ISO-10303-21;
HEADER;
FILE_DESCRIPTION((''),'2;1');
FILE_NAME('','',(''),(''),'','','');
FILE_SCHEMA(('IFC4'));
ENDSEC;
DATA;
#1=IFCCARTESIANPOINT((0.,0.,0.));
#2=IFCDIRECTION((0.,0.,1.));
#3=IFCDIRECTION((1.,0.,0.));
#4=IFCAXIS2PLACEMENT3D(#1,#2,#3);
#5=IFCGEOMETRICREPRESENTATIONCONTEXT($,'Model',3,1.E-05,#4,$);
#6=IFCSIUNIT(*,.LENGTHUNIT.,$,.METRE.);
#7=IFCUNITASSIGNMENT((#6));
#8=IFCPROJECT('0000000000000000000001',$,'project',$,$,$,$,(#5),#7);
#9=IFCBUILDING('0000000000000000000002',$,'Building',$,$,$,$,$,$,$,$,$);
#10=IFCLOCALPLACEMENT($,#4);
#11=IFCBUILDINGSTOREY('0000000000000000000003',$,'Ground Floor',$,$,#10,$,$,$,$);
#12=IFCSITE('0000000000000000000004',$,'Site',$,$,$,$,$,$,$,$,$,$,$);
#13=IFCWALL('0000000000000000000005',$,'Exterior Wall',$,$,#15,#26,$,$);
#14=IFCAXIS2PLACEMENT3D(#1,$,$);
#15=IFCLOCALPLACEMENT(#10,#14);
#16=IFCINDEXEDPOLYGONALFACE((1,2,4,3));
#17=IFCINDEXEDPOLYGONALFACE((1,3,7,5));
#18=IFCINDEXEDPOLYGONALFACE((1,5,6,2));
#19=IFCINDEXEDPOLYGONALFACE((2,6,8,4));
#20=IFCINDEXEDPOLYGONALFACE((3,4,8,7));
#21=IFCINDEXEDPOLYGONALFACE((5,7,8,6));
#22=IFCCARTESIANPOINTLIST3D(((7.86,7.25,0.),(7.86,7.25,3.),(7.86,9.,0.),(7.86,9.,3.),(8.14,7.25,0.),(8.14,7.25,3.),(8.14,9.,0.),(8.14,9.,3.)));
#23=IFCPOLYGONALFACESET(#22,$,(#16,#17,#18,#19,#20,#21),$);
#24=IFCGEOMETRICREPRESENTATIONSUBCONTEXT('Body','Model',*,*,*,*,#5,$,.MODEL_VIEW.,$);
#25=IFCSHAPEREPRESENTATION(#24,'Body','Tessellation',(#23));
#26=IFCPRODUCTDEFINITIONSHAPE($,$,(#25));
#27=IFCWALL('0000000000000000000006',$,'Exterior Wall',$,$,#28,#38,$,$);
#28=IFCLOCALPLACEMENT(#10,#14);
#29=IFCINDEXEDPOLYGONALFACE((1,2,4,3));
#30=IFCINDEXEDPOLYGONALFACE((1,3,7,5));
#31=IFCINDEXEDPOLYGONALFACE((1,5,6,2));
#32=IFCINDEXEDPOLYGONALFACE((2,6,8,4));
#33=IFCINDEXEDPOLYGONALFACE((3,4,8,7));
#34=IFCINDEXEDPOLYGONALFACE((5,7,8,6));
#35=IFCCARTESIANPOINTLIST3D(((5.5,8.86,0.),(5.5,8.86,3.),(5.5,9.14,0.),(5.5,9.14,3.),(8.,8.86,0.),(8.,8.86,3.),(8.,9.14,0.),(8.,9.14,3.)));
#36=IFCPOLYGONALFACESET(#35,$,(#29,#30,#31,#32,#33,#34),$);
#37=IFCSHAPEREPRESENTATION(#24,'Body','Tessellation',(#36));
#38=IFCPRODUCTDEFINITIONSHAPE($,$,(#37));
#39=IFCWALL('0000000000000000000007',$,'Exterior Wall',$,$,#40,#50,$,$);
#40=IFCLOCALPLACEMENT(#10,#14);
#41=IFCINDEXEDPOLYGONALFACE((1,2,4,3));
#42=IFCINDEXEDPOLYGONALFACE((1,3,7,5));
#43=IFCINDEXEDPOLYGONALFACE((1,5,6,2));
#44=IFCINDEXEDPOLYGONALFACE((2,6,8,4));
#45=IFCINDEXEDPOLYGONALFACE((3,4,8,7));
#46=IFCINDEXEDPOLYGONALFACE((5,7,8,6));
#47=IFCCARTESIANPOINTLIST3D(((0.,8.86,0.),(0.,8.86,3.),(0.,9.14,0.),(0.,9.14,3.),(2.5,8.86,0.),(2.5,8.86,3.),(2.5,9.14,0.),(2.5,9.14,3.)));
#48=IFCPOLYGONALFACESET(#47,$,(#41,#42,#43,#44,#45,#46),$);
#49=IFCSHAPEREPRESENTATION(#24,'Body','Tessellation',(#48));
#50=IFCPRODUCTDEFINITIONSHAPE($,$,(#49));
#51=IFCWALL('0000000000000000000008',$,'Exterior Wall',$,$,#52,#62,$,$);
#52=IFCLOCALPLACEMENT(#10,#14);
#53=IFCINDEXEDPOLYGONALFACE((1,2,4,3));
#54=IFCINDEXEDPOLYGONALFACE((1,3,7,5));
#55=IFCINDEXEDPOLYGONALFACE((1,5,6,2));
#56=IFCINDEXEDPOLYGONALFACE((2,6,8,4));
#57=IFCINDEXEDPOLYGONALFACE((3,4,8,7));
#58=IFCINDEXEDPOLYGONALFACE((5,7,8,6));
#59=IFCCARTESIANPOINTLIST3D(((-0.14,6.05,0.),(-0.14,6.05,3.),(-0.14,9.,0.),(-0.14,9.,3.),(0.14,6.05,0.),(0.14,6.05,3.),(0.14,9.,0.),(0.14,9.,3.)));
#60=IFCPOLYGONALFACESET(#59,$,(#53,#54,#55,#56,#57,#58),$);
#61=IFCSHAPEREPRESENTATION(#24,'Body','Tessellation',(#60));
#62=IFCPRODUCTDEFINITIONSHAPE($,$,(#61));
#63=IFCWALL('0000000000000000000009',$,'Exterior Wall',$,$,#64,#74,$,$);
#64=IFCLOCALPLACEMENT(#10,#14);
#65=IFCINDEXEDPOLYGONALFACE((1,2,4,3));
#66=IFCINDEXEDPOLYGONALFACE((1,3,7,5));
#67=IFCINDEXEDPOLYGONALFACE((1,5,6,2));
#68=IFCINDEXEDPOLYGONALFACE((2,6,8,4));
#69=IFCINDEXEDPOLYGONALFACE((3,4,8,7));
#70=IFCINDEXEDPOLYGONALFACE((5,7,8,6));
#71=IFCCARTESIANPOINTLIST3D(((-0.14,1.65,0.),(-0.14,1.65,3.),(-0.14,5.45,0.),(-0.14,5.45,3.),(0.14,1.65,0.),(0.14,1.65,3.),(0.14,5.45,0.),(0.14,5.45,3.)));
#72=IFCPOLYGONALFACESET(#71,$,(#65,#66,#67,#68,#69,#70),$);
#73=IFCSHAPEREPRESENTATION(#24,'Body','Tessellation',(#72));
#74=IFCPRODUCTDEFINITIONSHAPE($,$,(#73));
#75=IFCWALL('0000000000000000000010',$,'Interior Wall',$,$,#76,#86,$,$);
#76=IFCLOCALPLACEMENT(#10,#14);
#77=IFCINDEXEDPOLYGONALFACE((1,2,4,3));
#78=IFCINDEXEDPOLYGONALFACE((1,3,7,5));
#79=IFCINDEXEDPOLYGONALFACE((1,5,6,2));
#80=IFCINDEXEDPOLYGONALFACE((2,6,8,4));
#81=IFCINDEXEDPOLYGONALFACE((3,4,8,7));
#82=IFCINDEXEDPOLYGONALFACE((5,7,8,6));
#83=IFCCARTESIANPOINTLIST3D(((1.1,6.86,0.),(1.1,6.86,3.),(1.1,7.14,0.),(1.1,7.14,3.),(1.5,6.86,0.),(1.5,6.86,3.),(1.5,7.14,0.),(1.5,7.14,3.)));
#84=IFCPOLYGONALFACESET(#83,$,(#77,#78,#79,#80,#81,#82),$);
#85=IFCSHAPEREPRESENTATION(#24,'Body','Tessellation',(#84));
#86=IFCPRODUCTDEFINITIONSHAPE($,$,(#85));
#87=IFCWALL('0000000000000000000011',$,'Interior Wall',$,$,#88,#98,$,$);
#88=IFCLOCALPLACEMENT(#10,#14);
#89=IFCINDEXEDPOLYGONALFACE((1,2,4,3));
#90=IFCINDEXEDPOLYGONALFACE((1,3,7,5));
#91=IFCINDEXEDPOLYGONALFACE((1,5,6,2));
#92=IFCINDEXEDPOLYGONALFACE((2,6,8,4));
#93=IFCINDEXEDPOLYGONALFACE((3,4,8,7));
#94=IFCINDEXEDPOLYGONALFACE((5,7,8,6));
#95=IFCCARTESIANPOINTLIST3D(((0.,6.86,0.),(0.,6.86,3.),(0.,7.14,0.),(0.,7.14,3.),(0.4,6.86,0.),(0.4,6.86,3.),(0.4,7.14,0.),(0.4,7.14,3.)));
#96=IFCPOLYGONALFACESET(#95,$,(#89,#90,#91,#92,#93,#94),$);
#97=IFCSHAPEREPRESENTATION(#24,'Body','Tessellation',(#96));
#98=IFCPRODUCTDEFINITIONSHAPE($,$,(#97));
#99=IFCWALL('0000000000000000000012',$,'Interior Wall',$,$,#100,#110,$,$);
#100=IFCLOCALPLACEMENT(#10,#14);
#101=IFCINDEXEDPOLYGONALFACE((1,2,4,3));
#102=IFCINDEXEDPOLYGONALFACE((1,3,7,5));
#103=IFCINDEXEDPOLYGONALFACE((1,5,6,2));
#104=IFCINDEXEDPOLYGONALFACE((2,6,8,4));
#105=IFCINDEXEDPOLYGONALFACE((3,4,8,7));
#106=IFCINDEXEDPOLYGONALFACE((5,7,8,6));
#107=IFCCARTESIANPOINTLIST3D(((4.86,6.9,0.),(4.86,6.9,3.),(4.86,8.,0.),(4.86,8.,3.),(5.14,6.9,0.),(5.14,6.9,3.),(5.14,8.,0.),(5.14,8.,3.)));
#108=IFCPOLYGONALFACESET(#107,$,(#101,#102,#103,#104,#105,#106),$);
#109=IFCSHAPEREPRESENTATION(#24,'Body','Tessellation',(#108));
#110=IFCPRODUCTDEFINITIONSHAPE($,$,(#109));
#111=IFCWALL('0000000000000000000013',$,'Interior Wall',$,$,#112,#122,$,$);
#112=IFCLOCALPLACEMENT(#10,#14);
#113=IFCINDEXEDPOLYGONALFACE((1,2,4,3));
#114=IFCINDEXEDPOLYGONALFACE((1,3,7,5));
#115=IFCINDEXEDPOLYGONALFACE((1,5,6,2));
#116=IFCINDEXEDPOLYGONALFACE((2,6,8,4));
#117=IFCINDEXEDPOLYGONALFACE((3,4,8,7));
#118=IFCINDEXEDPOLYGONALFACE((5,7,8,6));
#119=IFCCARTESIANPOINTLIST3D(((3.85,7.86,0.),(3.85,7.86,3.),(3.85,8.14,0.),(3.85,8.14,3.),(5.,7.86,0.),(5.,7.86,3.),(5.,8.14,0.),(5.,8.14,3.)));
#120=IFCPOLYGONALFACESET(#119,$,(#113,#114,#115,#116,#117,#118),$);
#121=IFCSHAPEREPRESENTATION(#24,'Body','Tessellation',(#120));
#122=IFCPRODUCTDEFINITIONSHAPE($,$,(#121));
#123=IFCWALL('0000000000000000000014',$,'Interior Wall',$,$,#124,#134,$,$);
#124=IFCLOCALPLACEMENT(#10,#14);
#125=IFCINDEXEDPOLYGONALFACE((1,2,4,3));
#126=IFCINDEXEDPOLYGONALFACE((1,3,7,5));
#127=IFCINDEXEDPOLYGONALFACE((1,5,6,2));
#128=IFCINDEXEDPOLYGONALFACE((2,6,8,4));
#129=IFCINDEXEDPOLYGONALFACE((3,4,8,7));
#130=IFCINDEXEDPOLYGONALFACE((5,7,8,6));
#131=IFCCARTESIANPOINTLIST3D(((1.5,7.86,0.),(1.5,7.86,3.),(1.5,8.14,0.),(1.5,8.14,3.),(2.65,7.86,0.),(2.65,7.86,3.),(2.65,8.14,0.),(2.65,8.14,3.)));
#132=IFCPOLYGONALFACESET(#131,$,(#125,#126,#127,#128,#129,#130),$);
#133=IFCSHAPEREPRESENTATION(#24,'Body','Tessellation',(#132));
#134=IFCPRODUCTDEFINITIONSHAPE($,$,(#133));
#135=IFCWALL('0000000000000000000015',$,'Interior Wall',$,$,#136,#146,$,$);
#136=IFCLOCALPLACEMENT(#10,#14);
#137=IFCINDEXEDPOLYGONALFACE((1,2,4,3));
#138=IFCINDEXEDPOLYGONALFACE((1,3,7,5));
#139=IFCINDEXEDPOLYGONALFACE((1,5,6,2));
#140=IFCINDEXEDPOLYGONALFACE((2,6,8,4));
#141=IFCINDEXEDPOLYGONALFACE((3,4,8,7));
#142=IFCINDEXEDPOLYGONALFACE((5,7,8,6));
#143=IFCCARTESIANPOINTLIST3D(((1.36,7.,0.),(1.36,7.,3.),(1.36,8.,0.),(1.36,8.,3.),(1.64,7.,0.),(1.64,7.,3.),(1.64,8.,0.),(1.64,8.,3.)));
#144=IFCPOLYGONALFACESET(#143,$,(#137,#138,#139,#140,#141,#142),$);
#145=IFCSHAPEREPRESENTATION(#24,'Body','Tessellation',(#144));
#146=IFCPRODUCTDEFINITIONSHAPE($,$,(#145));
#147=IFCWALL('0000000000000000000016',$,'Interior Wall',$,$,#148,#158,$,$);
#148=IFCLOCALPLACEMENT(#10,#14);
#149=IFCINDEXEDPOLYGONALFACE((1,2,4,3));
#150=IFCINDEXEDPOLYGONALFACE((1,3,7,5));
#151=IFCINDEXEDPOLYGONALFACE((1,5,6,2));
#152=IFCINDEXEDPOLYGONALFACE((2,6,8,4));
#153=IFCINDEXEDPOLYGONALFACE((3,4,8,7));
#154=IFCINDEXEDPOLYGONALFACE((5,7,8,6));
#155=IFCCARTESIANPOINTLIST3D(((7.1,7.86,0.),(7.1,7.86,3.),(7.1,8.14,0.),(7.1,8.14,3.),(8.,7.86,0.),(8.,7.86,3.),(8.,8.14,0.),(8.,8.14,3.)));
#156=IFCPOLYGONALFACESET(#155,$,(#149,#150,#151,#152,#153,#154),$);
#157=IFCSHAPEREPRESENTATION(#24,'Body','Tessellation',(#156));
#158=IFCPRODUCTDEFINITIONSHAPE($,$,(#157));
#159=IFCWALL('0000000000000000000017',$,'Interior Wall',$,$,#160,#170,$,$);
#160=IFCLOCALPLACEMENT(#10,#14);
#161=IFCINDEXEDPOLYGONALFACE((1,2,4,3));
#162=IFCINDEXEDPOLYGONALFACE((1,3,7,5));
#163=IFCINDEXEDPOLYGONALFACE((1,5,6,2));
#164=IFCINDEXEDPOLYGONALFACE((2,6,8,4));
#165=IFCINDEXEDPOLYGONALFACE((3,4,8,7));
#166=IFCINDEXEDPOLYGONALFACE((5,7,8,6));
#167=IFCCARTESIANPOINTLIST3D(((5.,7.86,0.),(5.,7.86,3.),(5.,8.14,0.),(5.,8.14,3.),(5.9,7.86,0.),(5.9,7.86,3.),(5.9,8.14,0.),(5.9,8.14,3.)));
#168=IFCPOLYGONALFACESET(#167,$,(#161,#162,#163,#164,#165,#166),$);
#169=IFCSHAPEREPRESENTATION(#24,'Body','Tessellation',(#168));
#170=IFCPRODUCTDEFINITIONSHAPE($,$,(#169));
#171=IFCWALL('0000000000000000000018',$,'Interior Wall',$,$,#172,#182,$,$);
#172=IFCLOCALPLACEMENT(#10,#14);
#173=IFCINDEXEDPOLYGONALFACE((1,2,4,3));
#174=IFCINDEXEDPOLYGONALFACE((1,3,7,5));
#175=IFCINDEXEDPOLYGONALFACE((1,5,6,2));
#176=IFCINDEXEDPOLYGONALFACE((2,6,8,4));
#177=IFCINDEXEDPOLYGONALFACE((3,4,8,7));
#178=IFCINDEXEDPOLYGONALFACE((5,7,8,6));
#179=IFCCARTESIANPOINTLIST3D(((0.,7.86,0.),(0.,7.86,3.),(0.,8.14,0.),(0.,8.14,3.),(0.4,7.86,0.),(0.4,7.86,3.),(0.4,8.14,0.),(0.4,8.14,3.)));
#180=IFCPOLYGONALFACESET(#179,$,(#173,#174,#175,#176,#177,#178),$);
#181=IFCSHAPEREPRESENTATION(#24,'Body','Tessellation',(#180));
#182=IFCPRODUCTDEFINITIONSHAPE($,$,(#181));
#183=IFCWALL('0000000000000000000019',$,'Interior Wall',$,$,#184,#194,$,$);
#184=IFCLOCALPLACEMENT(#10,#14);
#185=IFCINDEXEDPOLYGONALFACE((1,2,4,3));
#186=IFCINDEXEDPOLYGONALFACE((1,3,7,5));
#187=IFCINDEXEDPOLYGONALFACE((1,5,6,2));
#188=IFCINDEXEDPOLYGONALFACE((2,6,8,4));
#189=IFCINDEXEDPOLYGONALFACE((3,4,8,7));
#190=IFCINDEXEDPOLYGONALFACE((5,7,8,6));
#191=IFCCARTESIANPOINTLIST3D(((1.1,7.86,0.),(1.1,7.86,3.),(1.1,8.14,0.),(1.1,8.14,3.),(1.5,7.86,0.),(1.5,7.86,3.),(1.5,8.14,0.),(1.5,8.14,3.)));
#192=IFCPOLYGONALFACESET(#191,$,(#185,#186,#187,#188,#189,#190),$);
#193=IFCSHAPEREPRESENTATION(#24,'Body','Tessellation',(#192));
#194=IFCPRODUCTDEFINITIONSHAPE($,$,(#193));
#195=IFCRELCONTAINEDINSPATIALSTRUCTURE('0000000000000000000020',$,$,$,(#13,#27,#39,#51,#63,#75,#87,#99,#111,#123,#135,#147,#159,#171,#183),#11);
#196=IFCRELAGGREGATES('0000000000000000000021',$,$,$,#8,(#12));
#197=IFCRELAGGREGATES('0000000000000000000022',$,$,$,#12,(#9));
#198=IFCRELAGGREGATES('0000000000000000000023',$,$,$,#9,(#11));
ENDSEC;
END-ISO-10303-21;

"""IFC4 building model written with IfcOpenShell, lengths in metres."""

from ifc_helpers import new_model, si_unit, frame, origin_with_axes, place, context, subcontext, project, spatial, indexed_curve, outline, extrude, element, save


model = new_model("IFC4")

# Units and contexts
model_context = context("Model", 3, precision=1e-05, world=origin_with_axes())
body_context = subcontext(model_context, "Body", "Model", "MODEL_VIEW")
ifc_project = project(units=[si_unit("LENGTHUNIT", "METRE")], contexts=[model_context])

# Site, building, storey
site = spatial("IfcSite", under=ifc_project, Name="Site")
building = spatial("IfcBuilding", under=site, Name="Building")
storey_placement = place(None, origin_with_axes())
storey = spatial("IfcBuildingStorey", under=building, at=storey_placement, Name="Ground Floor")

# Walls
wall_1_placement = place(storey_placement, frame((8.0, 7.25, 0.0), z_axis=(0.0, 0.0, 1.0), x_axis=(0.0, 1.0, 0.0)))
element("IfcWall", 1, at=wall_1_placement, inside=storey, Name="Exterior Wall", context=body_context, shape_type="SweptSolid", body=[
    extrude(outline(indexed_curve([(0.0, 0.0), (0.0, 0.28), (1.75, 0.28), (1.75, 0.0), (0.0, 0.0)], self_intersect=False)), frame((0.0, -0.14, 0.0), z_axis=(0.0, 0.0, 1.0), x_axis=(1.0, 0.0, 0.0)), (0.0, 0.0, 1.0), 3.0),
])
for number, where, z_axis, x_axis, name in (
    (2, (8.0, 9.0, 0.0), (0.0, 0.0, 1.0), (-1.0, 0.0, 0.0), "Exterior Wall"),
    (3, (2.5, 9.0, 0.0), (0.0, 0.0, 1.0), (-1.0, 0.0, 0.0), "Exterior Wall"),
):
    element("IfcWall", number, at=place(storey_placement, frame(where, z_axis=z_axis, x_axis=x_axis)), inside=storey, Name=name, context=body_context, shape_type="SweptSolid", body=[
        extrude(outline(indexed_curve([(0.0, 0.0), (0.0, 0.28), (2.5, 0.28), (2.5, 0.0), (0.0, 0.0)], self_intersect=False)), frame((0.0, -0.14, 0.0), z_axis=(0.0, 0.0, 1.0), x_axis=(1.0, 0.0, 0.0)), (0.0, 0.0, 1.0), 3.0),
    ])
wall_2_placement = place(storey_placement, frame((0.0, 9.0, 0.0), z_axis=(0.0, 0.0, 1.0), x_axis=(0.0, -1.0, 0.0)))
element("IfcWall", 4, at=wall_2_placement, inside=storey, Name="Exterior Wall", context=body_context, shape_type="SweptSolid", body=[
    extrude(outline(indexed_curve([(0.0, 0.0), (0.0, 0.28), (2.95, 0.28), (2.95, 0.0), (0.0, 0.0)], self_intersect=False)), frame((0.0, -0.14, 0.0), z_axis=(0.0, 0.0, 1.0), x_axis=(1.0, 0.0, 0.0)), (0.0, 0.0, 1.0), 3.0),
])
wall_3_placement = place(storey_placement, frame((0.0, 5.45, 0.0), z_axis=(0.0, 0.0, 1.0), x_axis=(0.0, -1.0, 0.0)))
element("IfcWall", 5, at=wall_3_placement, inside=storey, Name="Exterior Wall", context=body_context, shape_type="SweptSolid", body=[
    extrude(outline(indexed_curve([(0.0, 0.0), (0.0, 0.28), (3.8, 0.28), (3.8, 0.0), (0.0, 0.0)], self_intersect=False)), frame((0.0, -0.14, 0.0), z_axis=(0.0, 0.0, 1.0), x_axis=(1.0, 0.0, 0.0)), (0.0, 0.0, 1.0), 3.0),
])
for number, where, z_axis, x_axis, name in (
    (6, (1.5, 7.0, 0.0), (0.0, 0.0, 1.0), (-1.0, 0.0, 0.0), "Interior Wall"),
    (7, (0.4, 7.0, 0.0), (0.0, 0.0, 1.0), (-1.0, 0.0, 0.0), "Interior Wall"),
):
    element("IfcWall", number, at=place(storey_placement, frame(where, z_axis=z_axis, x_axis=x_axis)), inside=storey, Name=name, context=body_context, shape_type="SweptSolid", body=[
        extrude(outline(indexed_curve([(0.0, 0.0), (0.0, 0.28), (0.4, 0.28), (0.4, 0.0), (0.0, 0.0)], self_intersect=False)), frame((0.0, -0.14, 0.0), z_axis=(0.0, 0.0, 1.0), x_axis=(1.0, 0.0, 0.0)), (0.0, 0.0, 1.0), 3.0),
    ])
wall_4_placement = place(storey_placement, frame((5.0, 6.9, 0.0), z_axis=(0.0, 0.0, 1.0), x_axis=(0.0, 1.0, 0.0)))
element("IfcWall", 8, at=wall_4_placement, inside=storey, Name="Interior Wall", context=body_context, shape_type="SweptSolid", body=[
    extrude(outline(indexed_curve([(0.0, 0.0), (0.0, 0.28), (1.1, 0.28), (1.1, 0.0), (0.0, 0.0)], self_intersect=False)), frame((0.0, -0.14, 0.0), z_axis=(0.0, 0.0, 1.0), x_axis=(1.0, 0.0, 0.0)), (0.0, 0.0, 1.0), 3.0),
])
for number, where, z_axis, x_axis, name in (
    (9, (5.0, 8.0, 0.0), (0.0, 0.0, 1.0), (-1.0, 0.0, 0.0), "Interior Wall"),
    (10, (2.65, 8.0, 0.0), (0.0, 0.0, 1.0), (-1.0, 0.0, 0.0), "Interior Wall"),
):
    element("IfcWall", number, at=place(storey_placement, frame(where, z_axis=z_axis, x_axis=x_axis)), inside=storey, Name=name, context=body_context, shape_type="SweptSolid", body=[
        extrude(outline(indexed_curve([(0.0, 0.0), (0.0, 0.28), (1.15, 0.28), (1.15, 0.0), (0.0, 0.0)], self_intersect=False)), frame((0.0, -0.14, 0.0), z_axis=(0.0, 0.0, 1.0), x_axis=(1.0, 0.0, 0.0)), (0.0, 0.0, 1.0), 3.0),
    ])
wall_5_placement = place(storey_placement, frame((1.5, 8.0, 0.0), z_axis=(0.0, 0.0, 1.0), x_axis=(0.0, -1.0, 0.0)))
element("IfcWall", 11, at=wall_5_placement, inside=storey, Name="Interior Wall", context=body_context, shape_type="SweptSolid", body=[
    extrude(outline(indexed_curve([(0.0, 0.0), (0.0, 0.28), (1.0, 0.28), (1.0, 0.0), (0.0, 0.0)], self_intersect=False)), frame((0.0, -0.14, 0.0), z_axis=(0.0, 0.0, 1.0), x_axis=(1.0, 0.0, 0.0)), (0.0, 0.0, 1.0), 3.0),
])
for number, where, z_axis, x_axis, name in (
    (12, (8.0, 8.0, 0.0), (0.0, 0.0, 1.0), (-1.0, 0.0, 0.0), "Interior Wall"),
    (13, (5.9, 8.0, 0.0), (0.0, 0.0, 1.0), (-1.0, 0.0, 0.0), "Interior Wall"),
):
    element("IfcWall", number, at=place(storey_placement, frame(where, z_axis=z_axis, x_axis=x_axis)), inside=storey, Name=name, context=body_context, shape_type="SweptSolid", body=[
        extrude(outline(indexed_curve([(0.0, 0.0), (0.0, 0.28), (0.9, 0.28), (0.9, 0.0), (0.0, 0.0)], self_intersect=False)), frame((0.0, -0.14, 0.0), z_axis=(0.0, 0.0, 1.0), x_axis=(1.0, 0.0, 0.0)), (0.0, 0.0, 1.0), 3.0),
    ])
wall_6_placement = place(storey_placement, frame((0.0, 8.0, 0.0), z_axis=(0.0, 0.0, 1.0), x_axis=(1.0, 0.0, 0.0)))
element("IfcWall", 14, at=wall_6_placement, inside=storey, Name="Interior Wall", context=body_context, shape_type="SweptSolid", body=[
    extrude(outline(indexed_curve([(0.0, 0.0), (0.0, 0.28), (0.4, 0.28), (0.4, 0.0), (0.0, 0.0)], self_intersect=False)), frame((0.0, -0.14, 0.0), z_axis=(0.0, 0.0, 1.0), x_axis=(1.0, 0.0, 0.0)), (0.0, 0.0, 1.0), 3.0),
])
wall_7_placement = place(storey_placement, frame((1.1, 8.0, 0.0), z_axis=(0.0, 0.0, 1.0), x_axis=(1.0, 0.0, 0.0)))
element("IfcWall", 15, at=wall_7_placement, inside=storey, Name="Interior Wall", context=body_context, shape_type="SweptSolid", body=[
    extrude(outline(indexed_curve([(0.0, 0.0), (0.0, 0.28), (0.4, 0.28), (0.4, 0.0), (0.0, 0.0)], self_intersect=False)), frame((0.0, -0.14, 0.0), z_axis=(0.0, 0.0, 1.0), x_axis=(1.0, 0.0, 0.0)), (0.0, 0.0, 1.0), 3.0),
])

save(model, "model.ifc")
